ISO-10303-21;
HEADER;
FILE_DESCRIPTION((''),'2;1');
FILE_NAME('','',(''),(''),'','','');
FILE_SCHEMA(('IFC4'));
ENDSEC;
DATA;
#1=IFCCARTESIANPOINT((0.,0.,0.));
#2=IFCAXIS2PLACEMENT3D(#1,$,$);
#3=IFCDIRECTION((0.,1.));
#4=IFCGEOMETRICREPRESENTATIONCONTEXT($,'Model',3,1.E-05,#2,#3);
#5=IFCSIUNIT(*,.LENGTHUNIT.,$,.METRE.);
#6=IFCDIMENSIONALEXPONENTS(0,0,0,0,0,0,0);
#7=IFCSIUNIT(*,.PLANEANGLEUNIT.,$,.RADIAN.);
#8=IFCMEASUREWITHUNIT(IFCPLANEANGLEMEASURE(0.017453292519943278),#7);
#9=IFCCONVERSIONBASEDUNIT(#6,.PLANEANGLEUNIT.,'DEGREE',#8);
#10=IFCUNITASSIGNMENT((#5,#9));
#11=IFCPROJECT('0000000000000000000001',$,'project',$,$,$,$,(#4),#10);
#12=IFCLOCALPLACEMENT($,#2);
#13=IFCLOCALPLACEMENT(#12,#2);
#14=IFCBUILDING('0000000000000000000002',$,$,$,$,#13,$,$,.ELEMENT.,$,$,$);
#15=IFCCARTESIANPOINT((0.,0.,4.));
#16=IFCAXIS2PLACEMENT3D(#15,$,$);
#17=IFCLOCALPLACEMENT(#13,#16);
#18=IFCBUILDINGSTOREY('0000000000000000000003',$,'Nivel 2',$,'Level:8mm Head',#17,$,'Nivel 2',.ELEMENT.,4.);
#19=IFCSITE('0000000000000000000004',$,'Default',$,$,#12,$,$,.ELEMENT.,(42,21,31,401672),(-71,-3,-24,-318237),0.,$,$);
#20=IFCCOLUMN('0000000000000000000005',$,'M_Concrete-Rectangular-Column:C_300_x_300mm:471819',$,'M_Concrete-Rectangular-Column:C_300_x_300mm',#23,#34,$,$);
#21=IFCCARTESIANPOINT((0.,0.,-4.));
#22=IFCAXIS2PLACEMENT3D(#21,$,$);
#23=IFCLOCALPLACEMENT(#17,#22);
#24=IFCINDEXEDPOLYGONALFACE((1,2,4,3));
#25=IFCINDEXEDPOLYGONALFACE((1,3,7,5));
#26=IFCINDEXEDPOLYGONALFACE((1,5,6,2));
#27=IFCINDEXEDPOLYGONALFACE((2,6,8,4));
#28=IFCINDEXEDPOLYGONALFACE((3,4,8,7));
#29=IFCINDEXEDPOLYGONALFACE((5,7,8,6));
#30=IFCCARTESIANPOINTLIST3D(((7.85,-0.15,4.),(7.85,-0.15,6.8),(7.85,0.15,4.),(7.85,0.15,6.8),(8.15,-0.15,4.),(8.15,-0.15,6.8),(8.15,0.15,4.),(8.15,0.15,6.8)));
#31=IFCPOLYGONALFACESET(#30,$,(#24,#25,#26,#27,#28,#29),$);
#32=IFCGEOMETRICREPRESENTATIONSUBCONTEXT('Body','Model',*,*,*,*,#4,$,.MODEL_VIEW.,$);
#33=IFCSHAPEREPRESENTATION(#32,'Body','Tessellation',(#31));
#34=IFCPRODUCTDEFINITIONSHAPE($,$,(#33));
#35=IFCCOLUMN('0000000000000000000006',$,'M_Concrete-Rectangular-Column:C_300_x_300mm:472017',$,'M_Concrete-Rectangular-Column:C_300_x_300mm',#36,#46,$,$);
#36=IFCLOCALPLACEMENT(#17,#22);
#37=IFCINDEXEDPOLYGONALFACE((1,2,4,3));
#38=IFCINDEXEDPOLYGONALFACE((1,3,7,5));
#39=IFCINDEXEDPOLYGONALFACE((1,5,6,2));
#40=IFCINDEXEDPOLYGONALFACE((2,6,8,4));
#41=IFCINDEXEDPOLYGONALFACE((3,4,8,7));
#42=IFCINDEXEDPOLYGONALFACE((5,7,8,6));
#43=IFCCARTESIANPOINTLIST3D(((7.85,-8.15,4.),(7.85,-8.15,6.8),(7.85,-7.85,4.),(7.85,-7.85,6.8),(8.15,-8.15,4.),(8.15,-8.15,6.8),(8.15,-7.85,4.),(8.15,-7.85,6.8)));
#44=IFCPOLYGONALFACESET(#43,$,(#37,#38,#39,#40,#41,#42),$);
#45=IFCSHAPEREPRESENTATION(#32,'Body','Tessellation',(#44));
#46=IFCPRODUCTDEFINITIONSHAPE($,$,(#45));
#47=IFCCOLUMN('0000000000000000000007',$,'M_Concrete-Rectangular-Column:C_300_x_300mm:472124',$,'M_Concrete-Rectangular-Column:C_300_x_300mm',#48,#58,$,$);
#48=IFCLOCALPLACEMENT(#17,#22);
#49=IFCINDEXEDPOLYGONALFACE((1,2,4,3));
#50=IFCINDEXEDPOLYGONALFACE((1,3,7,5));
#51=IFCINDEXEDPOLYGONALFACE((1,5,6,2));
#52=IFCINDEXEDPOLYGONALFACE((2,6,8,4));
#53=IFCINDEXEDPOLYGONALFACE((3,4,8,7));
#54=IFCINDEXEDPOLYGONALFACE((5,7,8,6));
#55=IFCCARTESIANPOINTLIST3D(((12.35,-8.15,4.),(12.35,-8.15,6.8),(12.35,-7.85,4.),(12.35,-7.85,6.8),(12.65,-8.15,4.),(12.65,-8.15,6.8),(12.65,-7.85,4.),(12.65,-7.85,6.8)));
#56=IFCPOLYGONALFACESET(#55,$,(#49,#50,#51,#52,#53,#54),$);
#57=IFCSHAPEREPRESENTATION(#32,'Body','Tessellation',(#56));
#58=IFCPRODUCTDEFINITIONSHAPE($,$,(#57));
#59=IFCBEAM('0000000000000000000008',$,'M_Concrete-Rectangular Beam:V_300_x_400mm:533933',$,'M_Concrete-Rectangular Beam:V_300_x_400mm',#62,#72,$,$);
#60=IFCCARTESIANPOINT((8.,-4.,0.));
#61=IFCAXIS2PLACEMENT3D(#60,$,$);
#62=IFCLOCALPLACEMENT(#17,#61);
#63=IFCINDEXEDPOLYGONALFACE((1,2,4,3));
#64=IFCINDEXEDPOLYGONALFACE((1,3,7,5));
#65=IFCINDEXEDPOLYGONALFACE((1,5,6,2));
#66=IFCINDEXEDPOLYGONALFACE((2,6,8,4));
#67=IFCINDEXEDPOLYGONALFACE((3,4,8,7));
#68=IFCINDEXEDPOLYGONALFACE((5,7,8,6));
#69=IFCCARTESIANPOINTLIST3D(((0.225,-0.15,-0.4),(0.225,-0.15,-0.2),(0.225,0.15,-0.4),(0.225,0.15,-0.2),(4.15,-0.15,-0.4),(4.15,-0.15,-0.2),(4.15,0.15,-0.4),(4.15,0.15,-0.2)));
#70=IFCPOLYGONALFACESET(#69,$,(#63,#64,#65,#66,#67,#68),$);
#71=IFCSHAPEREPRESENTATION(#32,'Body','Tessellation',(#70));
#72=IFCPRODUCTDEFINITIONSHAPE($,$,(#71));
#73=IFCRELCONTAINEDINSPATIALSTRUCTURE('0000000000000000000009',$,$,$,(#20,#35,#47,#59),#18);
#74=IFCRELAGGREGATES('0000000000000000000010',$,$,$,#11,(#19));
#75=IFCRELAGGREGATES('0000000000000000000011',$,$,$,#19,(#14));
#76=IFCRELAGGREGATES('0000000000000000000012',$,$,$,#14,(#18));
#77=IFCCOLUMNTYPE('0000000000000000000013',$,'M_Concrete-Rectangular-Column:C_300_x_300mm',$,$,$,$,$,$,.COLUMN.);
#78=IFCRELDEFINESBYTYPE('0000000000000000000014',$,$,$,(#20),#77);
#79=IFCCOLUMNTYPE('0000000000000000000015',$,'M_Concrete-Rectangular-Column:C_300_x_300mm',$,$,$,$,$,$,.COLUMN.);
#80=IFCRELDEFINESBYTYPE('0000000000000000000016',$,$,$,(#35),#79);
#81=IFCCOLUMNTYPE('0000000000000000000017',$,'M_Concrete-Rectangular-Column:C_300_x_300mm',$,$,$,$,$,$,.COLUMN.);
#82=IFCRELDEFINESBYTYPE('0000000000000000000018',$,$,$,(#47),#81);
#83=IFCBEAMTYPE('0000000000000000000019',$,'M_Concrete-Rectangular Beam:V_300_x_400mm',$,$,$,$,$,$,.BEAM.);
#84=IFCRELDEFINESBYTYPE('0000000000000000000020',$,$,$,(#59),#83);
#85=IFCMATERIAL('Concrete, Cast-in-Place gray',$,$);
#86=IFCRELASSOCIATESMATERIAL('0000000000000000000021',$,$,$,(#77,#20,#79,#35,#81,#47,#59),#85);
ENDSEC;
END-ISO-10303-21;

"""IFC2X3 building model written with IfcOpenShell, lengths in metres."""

from ifc_helpers import new_model, entity, si_unit, converted_unit, direction, frame, frame_2d, origin, place, context, subcontext, project, spatial, rectangle, extrude, source, transform, mapped, material, type_object, type_shapes, element, save


model = new_model("IFC2X3")

# Units and contexts
model_context = context("Model", 3, precision=1e-05, world=origin(), true_north=direction((0.0, 1.0)))
body_context = subcontext(model_context, "Body", "Model", "MODEL_VIEW")
ifc_project = project(units=[si_unit("LENGTHUNIT", "METRE"), converted_unit("PLANEANGLEUNIT", "DEGREE", entity("IfcPlaneAngleMeasure", 0.017453292519943278), si_unit("PLANEANGLEUNIT", "RADIAN"), dimensions=[0, 0, 0, 0, 0, 0, 0])], contexts=[model_context])

# Site, building, storey
site_placement = place(None, origin())
site = spatial("IfcSite", under=ifc_project, at=site_placement, Name="Default", CompositionType="ELEMENT", RefLatitude=(42, 21, 31, 401672), RefLongitude=(-71, -3, -24, -318237), RefElevation=0.0)
building_placement = place(site_placement, origin())
building = spatial("IfcBuilding", under=site, at=building_placement, CompositionType="ELEMENT")
storey_placement = place(building_placement, frame((0.0, 0.0, 4.0)))
storey = spatial("IfcBuildingStorey", under=building, at=storey_placement, Name="Nivel 2", ObjectType="Level:8mm Head", LongName="Nivel 2", CompositionType="ELEMENT", Elevation=4.0)

# Columns
ifc_material_1 = material(Name="Concrete, Cast-in-Place gray")
column_type_1 = type_object("IfcColumnType", Name="M_Concrete-Rectangular-Column:C_300_x_300mm", PredefinedType="COLUMN", material=ifc_material_1)
shared_shape_1 = source(origin(), body_context, "Body", "SweptSolid", [
    extrude(rectangle(XDim=0.3, YDim=0.3, at=frame_2d((0.0, 0.0), x_axis=(1.0, 0.0))), frame((8.0, 0.0, 4.0), z_axis=(0.0, 0.0, 1.0), x_axis=(-1.0, 0.0, 0.0)), (0.0, 0.0, 1.0), 2.8),
])
type_shapes(column_type_1, [shared_shape_1])
column_1_placement = place(storey_placement, frame((0.0, 0.0, -4.0)))
element("IfcColumn", 1, at=column_1_placement, inside=storey, type_object=column_type_1, material=ifc_material_1, Name="M_Concrete-Rectangular-Column:C_300_x_300mm:471819", ObjectType="M_Concrete-Rectangular-Column:C_300_x_300mm", context=body_context, shape_type="MappedRepresentation", body=[
    mapped(shared_shape_1, transform((0.0, 0.0, 0.0), scale=1.0)),
])
column_type_2 = type_object("IfcColumnType", Name="M_Concrete-Rectangular-Column:C_300_x_300mm", PredefinedType="COLUMN", material=ifc_material_1)
shared_shape_2 = source(origin(), body_context, "Body", "SweptSolid", [
    extrude(rectangle(XDim=0.3, YDim=0.3, at=frame_2d((0.0, 0.0), x_axis=(1.0, 0.0))), frame((8.0, -8.0, 4.0), z_axis=(0.0, 0.0, 1.0), x_axis=(-1.0, 0.0, 0.0)), (0.0, 0.0, 1.0), 2.8),
])
type_shapes(column_type_2, [shared_shape_2])
column_2_placement = place(storey_placement, frame((0.0, 0.0, -4.0)))
element("IfcColumn", 2, at=column_2_placement, inside=storey, type_object=column_type_2, material=ifc_material_1, Name="M_Concrete-Rectangular-Column:C_300_x_300mm:472017", ObjectType="M_Concrete-Rectangular-Column:C_300_x_300mm", context=body_context, shape_type="MappedRepresentation", body=[
    mapped(shared_shape_2, transform((0.0, 0.0, 0.0), scale=1.0)),
])
column_type_3 = type_object("IfcColumnType", Name="M_Concrete-Rectangular-Column:C_300_x_300mm", PredefinedType="COLUMN", material=ifc_material_1)
shared_shape_3 = source(origin(), body_context, "Body", "SweptSolid", [
    extrude(rectangle(XDim=0.3, YDim=0.3, at=frame_2d((0.0, 0.0), x_axis=(1.0, 0.0))), frame((12.5, -8.0, 4.0), z_axis=(0.0, 0.0, 1.0), x_axis=(-1.0, 0.0, 0.0)), (0.0, 0.0, 1.0), 2.8),
])
type_shapes(column_type_3, [shared_shape_3])
column_3_placement = place(storey_placement, frame((0.0, 0.0, -4.0)))
element("IfcColumn", 3, at=column_3_placement, inside=storey, type_object=column_type_3, material=ifc_material_1, Name="M_Concrete-Rectangular-Column:C_300_x_300mm:472124", ObjectType="M_Concrete-Rectangular-Column:C_300_x_300mm", context=body_context, shape_type="MappedRepresentation", body=[
    mapped(shared_shape_3, transform((0.0, 0.0, 0.0), scale=1.0)),
])

# Beam
beam_type_1 = type_object("IfcBeamType", Name="M_Concrete-Rectangular Beam:V_300_x_400mm", PredefinedType="BEAM")
beam_1_placement = place(storey_placement, frame((8.0, -4.0, 0.0)))
element("IfcBeam", 4, at=beam_1_placement, inside=storey, type_object=beam_type_1, material=ifc_material_1, Name="M_Concrete-Rectangular Beam:V_300_x_400mm:533933", ObjectType="M_Concrete-Rectangular Beam:V_300_x_400mm", context=body_context, shape_type="SweptSolid", body=[
    extrude(rectangle(XDim=0.2, YDim=0.3, at=frame_2d((0.0, 0.0), x_axis=(1.0, 0.0))), frame((0.225, 0.0, -0.3), z_axis=(1.0, 0.0, 0.0), x_axis=(0.0, 0.0, -1.0)), (0.0, 0.0, 1.0), 3.925),
])

save(model, "model.ifc")
